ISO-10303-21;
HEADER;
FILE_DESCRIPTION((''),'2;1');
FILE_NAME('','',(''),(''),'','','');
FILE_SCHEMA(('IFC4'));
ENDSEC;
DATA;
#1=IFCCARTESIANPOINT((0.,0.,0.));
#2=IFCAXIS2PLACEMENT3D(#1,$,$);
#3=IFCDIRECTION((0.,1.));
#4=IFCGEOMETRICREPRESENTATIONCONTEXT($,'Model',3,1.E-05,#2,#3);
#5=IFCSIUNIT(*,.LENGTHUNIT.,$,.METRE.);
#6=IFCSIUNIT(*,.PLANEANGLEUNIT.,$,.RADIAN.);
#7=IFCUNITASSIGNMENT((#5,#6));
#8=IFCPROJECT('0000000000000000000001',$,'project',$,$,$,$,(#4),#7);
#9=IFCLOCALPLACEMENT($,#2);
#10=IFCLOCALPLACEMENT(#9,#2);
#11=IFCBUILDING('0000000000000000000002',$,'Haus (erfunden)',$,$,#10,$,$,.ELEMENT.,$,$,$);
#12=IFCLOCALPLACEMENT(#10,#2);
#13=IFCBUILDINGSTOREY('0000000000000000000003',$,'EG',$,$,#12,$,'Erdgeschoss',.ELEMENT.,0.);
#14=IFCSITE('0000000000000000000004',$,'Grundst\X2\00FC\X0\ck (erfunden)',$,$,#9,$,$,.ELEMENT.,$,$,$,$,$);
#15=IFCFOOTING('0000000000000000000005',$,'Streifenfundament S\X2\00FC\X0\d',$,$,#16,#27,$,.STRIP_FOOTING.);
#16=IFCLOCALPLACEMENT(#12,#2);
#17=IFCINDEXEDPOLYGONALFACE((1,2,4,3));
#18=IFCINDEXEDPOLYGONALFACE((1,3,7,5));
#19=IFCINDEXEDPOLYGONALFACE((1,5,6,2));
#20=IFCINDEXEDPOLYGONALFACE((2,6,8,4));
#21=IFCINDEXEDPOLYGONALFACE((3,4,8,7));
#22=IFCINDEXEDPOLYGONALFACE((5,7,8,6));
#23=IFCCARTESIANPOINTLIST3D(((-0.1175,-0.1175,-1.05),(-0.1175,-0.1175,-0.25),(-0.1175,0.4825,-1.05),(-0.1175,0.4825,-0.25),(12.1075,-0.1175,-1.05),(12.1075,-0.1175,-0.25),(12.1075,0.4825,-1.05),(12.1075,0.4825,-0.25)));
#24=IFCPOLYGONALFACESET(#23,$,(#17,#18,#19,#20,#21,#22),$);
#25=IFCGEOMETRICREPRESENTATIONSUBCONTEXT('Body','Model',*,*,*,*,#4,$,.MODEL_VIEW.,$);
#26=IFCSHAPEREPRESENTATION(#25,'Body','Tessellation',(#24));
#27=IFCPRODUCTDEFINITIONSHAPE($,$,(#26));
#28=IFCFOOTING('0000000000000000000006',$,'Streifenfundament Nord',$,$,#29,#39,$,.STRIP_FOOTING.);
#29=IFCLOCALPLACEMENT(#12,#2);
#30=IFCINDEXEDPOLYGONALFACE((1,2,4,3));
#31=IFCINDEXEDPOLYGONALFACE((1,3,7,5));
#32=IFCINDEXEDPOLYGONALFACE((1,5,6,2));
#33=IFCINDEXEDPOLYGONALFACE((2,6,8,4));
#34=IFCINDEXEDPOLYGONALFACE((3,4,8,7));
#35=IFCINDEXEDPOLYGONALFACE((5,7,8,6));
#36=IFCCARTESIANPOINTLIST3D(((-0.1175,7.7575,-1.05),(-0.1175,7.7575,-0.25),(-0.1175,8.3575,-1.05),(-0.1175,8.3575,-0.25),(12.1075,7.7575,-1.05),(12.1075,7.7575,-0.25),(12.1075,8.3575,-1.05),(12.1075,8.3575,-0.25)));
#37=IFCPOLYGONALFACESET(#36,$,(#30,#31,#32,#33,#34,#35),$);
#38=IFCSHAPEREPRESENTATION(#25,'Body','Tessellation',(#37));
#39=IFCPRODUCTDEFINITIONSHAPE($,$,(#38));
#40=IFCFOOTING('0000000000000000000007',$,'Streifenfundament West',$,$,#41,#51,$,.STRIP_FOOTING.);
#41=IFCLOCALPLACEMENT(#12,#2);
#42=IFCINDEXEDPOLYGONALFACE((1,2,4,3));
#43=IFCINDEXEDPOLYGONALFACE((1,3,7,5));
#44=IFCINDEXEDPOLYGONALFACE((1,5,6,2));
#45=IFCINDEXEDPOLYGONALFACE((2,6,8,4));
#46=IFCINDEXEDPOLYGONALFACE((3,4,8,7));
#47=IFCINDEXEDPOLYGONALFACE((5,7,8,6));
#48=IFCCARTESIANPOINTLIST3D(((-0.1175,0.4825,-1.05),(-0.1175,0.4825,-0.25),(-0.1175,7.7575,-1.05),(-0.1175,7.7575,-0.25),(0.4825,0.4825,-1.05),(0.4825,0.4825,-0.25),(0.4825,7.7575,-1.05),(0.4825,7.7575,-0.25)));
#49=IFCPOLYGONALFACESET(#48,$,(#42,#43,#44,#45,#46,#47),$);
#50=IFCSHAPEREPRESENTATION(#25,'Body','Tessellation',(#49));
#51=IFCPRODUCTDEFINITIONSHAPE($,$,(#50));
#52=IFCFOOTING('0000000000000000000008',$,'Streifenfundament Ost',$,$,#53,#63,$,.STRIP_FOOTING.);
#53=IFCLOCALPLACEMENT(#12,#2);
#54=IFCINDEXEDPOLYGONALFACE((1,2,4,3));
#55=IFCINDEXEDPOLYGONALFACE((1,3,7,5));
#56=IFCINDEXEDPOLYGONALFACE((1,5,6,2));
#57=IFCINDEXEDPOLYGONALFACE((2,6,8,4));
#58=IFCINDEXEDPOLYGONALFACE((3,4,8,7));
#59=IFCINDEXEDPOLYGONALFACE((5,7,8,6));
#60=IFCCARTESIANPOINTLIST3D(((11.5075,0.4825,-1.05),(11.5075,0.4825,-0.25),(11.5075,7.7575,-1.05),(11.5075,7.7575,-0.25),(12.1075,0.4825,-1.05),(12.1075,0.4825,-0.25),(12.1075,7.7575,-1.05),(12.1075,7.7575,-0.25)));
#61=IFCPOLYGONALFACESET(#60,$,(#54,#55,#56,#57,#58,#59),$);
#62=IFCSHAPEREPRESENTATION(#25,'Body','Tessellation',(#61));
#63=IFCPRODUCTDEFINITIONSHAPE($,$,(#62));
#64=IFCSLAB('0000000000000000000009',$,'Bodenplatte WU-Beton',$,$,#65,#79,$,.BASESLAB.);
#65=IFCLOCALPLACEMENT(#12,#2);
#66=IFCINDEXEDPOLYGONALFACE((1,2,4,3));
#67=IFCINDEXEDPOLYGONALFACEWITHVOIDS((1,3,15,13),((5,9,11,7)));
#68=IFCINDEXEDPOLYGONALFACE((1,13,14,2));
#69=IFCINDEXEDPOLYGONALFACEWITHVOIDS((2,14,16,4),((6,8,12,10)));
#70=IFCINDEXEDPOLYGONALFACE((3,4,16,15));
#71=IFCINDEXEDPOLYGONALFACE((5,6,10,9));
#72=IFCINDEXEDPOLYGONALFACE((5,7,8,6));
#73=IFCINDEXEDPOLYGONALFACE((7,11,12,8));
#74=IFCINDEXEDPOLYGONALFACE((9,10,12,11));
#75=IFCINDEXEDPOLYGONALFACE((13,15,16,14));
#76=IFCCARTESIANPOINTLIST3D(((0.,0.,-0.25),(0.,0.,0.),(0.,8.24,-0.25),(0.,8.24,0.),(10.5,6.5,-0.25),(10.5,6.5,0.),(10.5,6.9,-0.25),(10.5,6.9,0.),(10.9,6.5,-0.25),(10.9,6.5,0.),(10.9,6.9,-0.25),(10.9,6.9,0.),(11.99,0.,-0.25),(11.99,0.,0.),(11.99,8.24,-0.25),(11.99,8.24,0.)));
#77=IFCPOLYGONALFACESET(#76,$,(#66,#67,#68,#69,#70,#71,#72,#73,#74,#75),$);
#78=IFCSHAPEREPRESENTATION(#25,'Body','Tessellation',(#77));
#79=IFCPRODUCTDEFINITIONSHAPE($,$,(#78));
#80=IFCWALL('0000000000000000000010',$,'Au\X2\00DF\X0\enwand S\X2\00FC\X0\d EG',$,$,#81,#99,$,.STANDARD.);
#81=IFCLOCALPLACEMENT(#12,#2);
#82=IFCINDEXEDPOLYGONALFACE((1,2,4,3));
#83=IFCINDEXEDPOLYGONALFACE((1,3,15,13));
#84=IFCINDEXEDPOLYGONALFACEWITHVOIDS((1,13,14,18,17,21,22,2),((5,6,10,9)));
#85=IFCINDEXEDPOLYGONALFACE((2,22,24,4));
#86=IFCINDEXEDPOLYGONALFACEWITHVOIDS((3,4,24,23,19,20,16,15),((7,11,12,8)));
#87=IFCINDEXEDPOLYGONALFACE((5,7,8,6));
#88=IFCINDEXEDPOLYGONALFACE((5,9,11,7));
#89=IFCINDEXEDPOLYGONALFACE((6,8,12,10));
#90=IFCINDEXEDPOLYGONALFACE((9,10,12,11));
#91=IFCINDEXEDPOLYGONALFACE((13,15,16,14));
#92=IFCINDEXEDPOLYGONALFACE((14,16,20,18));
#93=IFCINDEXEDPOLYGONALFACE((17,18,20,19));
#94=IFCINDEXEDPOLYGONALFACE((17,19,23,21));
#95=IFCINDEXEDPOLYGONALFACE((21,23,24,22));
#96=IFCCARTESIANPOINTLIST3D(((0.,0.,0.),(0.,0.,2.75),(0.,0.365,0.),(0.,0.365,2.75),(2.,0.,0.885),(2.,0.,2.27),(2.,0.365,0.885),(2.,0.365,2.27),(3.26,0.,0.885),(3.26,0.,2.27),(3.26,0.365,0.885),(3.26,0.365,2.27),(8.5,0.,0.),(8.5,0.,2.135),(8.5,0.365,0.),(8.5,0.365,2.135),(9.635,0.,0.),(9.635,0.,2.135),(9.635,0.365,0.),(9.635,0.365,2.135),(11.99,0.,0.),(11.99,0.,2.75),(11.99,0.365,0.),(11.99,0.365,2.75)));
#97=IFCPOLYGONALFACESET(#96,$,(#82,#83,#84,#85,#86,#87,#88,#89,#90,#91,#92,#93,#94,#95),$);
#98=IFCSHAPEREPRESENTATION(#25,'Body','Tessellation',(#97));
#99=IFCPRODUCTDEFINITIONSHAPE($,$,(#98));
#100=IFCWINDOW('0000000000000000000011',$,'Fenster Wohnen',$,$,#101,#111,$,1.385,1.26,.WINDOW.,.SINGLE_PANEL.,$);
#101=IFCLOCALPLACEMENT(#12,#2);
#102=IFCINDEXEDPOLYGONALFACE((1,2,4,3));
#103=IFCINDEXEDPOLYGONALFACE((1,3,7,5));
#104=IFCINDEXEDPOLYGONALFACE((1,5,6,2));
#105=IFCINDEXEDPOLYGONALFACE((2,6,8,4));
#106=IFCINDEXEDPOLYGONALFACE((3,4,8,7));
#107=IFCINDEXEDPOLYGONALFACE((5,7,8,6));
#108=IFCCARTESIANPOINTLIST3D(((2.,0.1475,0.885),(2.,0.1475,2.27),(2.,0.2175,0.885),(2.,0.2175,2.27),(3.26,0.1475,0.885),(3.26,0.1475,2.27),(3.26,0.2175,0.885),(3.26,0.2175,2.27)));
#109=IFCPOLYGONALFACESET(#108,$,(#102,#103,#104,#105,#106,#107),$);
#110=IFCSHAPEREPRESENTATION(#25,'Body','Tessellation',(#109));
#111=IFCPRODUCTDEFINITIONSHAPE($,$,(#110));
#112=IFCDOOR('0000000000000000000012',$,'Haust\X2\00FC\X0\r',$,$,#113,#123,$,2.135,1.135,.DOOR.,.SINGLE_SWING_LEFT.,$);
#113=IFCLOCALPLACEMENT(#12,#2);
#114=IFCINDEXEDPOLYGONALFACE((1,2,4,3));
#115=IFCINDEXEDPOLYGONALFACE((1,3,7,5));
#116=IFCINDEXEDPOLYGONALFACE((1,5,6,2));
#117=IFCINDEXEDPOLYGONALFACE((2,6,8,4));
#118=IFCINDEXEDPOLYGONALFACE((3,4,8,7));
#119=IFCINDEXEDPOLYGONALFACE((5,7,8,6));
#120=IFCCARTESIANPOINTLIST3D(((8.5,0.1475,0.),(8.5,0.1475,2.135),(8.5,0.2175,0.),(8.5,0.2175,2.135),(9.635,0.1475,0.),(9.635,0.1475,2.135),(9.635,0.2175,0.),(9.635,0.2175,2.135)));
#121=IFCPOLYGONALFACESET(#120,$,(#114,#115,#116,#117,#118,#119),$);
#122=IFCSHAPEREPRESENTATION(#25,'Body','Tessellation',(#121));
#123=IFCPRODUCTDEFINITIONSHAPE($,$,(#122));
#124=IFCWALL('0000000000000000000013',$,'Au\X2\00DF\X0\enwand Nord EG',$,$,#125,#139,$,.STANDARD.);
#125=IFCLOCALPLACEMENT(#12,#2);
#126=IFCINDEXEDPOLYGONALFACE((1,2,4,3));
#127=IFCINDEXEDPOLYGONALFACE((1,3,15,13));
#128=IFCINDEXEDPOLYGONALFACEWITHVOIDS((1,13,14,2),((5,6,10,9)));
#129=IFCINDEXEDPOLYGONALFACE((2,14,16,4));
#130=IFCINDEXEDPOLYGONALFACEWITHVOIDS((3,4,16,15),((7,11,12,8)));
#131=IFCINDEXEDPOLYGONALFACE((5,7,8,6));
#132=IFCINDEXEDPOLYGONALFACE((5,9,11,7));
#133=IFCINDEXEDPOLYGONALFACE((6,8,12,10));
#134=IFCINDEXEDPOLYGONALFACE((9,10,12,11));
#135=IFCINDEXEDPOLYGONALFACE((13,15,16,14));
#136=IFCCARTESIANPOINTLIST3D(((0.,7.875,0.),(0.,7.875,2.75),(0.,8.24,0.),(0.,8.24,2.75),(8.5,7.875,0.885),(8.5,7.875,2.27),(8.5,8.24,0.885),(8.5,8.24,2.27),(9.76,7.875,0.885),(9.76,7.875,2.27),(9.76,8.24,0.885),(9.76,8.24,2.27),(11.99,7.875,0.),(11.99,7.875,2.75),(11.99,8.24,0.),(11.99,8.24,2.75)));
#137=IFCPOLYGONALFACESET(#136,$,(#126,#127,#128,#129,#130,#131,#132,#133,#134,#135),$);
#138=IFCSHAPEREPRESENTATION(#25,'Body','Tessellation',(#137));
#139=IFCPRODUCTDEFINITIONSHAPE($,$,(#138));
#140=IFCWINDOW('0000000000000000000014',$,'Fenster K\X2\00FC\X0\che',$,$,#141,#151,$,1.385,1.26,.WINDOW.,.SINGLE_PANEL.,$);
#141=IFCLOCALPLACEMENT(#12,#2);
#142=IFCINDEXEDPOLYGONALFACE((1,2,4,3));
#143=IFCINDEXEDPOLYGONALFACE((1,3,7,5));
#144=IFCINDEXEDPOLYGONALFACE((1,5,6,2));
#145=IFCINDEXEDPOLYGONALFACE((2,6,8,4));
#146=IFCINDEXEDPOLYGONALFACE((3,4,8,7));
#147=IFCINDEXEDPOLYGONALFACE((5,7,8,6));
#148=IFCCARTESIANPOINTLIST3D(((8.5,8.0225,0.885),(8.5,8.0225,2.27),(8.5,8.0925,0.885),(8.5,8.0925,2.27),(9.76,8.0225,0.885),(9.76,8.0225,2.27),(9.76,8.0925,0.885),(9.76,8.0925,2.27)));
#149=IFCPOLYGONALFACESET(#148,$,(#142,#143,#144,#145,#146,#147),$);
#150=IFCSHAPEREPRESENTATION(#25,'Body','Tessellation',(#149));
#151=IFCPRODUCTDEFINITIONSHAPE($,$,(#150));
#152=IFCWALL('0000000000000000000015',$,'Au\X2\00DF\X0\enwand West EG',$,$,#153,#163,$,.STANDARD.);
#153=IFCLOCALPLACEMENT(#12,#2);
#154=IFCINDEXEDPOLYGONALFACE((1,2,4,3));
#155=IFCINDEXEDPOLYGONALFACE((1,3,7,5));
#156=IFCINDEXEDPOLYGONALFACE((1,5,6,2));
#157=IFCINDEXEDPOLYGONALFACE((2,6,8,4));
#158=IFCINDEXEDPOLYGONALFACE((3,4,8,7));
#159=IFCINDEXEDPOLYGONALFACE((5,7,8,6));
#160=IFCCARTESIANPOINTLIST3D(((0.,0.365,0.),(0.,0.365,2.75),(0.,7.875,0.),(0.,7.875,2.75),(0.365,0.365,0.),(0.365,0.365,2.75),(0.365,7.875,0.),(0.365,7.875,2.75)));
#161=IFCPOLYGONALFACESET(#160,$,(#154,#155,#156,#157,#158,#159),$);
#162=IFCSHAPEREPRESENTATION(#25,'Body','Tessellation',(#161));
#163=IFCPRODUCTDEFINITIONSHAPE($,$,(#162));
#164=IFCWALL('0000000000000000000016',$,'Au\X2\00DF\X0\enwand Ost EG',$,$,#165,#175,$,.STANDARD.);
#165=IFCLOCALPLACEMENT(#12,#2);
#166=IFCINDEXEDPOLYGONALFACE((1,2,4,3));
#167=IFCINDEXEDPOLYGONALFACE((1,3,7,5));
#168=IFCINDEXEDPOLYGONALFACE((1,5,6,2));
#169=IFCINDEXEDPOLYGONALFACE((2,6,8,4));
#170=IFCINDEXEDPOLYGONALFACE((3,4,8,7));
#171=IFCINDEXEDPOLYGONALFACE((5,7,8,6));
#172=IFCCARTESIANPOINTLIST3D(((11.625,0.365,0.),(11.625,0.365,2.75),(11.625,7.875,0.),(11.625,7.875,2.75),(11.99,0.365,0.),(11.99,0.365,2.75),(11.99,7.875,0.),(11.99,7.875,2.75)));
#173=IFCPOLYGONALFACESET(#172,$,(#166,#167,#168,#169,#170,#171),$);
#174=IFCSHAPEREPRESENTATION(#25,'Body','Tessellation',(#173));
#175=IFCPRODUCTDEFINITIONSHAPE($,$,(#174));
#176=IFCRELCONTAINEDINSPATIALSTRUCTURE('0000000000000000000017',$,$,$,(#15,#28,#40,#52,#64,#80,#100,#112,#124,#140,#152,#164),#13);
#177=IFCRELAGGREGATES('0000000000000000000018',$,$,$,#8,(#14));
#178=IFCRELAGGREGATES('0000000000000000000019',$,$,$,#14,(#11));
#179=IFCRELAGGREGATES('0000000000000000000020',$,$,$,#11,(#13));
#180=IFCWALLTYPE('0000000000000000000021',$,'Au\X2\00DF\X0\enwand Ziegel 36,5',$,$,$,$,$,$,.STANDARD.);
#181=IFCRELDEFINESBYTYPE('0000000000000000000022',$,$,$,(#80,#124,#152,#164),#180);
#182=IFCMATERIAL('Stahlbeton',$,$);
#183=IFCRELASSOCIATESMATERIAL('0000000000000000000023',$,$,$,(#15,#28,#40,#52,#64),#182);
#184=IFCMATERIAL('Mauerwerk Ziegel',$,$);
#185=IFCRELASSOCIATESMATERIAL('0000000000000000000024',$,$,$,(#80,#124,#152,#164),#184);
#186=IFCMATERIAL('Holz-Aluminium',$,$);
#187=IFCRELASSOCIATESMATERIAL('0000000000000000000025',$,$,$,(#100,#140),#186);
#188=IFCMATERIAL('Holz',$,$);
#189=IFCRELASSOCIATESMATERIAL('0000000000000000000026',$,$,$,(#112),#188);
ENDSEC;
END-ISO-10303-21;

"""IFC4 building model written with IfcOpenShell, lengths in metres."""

from ifc_helpers import new_model, si_unit, direction, frame, frame_2d, origin, place, context, subcontext, project, spatial, rectangle, extrude, material, type_object, element, fill, save


model = new_model("IFC4")

# Units and contexts
model_context = context("Model", 3, precision=1e-05, world=origin(), true_north=direction((0.0, 1.0)))
body_context = subcontext(model_context, "Body", "Model", "MODEL_VIEW")
ifc_project = project(units=[si_unit("LENGTHUNIT", "METRE"), si_unit("PLANEANGLEUNIT", "RADIAN")], contexts=[model_context])

# Site, building, storey
site_placement = place(None, origin())
site = spatial("IfcSite", under=ifc_project, at=site_placement, Name="Grundstück (erfunden)", CompositionType="ELEMENT")
building_placement = place(site_placement, origin())
building = spatial("IfcBuilding", under=site, at=building_placement, Name="Haus (erfunden)", CompositionType="ELEMENT")
storey_placement = place(building_placement, origin())
storey = spatial("IfcBuildingStorey", under=building, at=storey_placement, Name="EG", LongName="Erdgeschoss", CompositionType="ELEMENT", Elevation=0.0)

# Footings
ifc_material_1 = material(Name="Stahlbeton")
for number, where, name in (
    (1, (-0.1175, -0.1175, -1.05), "Streifenfundament Süd"),
    (2, (-0.1175, 7.7575, -1.05), "Streifenfundament Nord"),
):
    element("IfcFooting", number, at=place(storey_placement, frame(where)), inside=storey, material=ifc_material_1, Name=name, PredefinedType="STRIP_FOOTING", context=body_context, shape_type="SweptSolid", body=[
        extrude(rectangle(XDim=12.225, YDim=0.6, at=frame_2d((6.1125, 0.3))), origin(), (0.0, 0.0, 1.0), 0.8),
    ])
for number, where, name in (
    (3, (-0.1175, 0.4825, -1.05), "Streifenfundament West"),
    (4, (11.5075, 0.4825, -1.05), "Streifenfundament Ost"),
):
    element("IfcFooting", number, at=place(storey_placement, frame(where)), inside=storey, material=ifc_material_1, Name=name, PredefinedType="STRIP_FOOTING", context=body_context, shape_type="SweptSolid", body=[
        extrude(rectangle(XDim=0.6, YDim=7.275, at=frame_2d((0.3, 3.6375))), origin(), (0.0, 0.0, 1.0), 0.8),
    ])

# Slab, opening
slab_placement = place(storey_placement, frame((0.0, 0.0, -0.25)))
slab = element("IfcSlab", 5, at=slab_placement, inside=storey, material=ifc_material_1, Name="Bodenplatte WU-Beton", PredefinedType="BASESLAB", context=body_context, shape_type="SweptSolid", body=[
    extrude(rectangle(XDim=11.99, YDim=8.24, at=frame_2d((5.995, 4.12))), origin(), (0.0, 0.0, 1.0), 0.25),
])
opening_1_placement = place(slab_placement, frame((10.5, 6.5, -0.05)))
element("IfcOpeningElement", 6, at=opening_1_placement, cuts=slab, PredefinedType="OPENING", context=body_context, shape_type="SweptSolid", body=[
    extrude(rectangle(XDim=0.4, YDim=0.4, at=frame_2d((0.2, 0.2))), origin(), (0.0, 0.0, 1.0), 0.35),
])

# Wall, openings, window, door
ifc_material_2 = material(Name="Mauerwerk Ziegel")
wall_type_1 = type_object("IfcWallType", Name="Außenwand Ziegel 36,5", PredefinedType="STANDARD")
wall_1_placement = place(storey_placement, origin())
wall_1 = element("IfcWall", 7, at=wall_1_placement, inside=storey, type_object=wall_type_1, material=ifc_material_2, Name="Außenwand Süd EG", PredefinedType="STANDARD", context=body_context, shape_type="SweptSolid", body=[
    extrude(rectangle(XDim=11.99, YDim=0.365, at=frame_2d((5.995, 0.1825))), origin(), (0.0, 0.0, 1.0), 2.75),
])
opening_2_placement = place(wall_1_placement, frame((2.0, -0.05, 0.885)))
opening_2 = element("IfcOpeningElement", 8, at=opening_2_placement, cuts=wall_1, PredefinedType="OPENING", context=body_context, shape_type="SweptSolid", body=[
    extrude(rectangle(XDim=1.26, YDim=0.465, at=frame_2d((0.63, 0.2325))), origin(), (0.0, 0.0, 1.0), 1.385),
])
opening_3_placement = place(wall_1_placement, frame((8.5, -0.05, 0.0)))
opening_3 = element("IfcOpeningElement", 9, at=opening_3_placement, cuts=wall_1, PredefinedType="OPENING", context=body_context, shape_type="SweptSolid", body=[
    extrude(rectangle(XDim=1.135, YDim=0.465, at=frame_2d((0.5675, 0.2325))), origin(), (0.0, 0.0, 1.0), 2.135),
])
ifc_material_3 = material(Name="Holz-Aluminium")
window_1_placement = place(opening_2_placement, frame((0.0, 0.1975, 0.0)))
window_1 = element("IfcWindow", 10, at=window_1_placement, inside=storey, material=ifc_material_3, Name="Fenster Wohnen", OverallHeight=1.385, OverallWidth=1.26, PartitioningType="SINGLE_PANEL", PredefinedType="WINDOW", context=body_context, shape_type="SweptSolid", body=[
    extrude(rectangle(XDim=1.26, YDim=0.07, at=frame_2d((0.63, 0.035))), origin(), (0.0, 0.0, 1.0), 1.385),
])
fill(opening_2, window_1)
ifc_material_4 = material(Name="Holz")
door_1_placement = place(opening_3_placement, frame((0.0, 0.1975, 0.0)))
door_1 = element("IfcDoor", 11, at=door_1_placement, inside=storey, material=ifc_material_4, Name="Haustür", OperationType="SINGLE_SWING_LEFT", OverallHeight=2.135, OverallWidth=1.135, PredefinedType="DOOR", context=body_context, shape_type="SweptSolid", body=[
    extrude(rectangle(XDim=1.135, YDim=0.07, at=frame_2d((0.5675, 0.035))), origin(), (0.0, 0.0, 1.0), 2.135),
])
fill(opening_3, door_1)

# Wall, opening, window
wall_2_placement = place(storey_placement, frame((0.0, 7.875, 0.0)))
wall_2 = element("IfcWall", 12, at=wall_2_placement, inside=storey, type_object=wall_type_1, material=ifc_material_2, Name="Außenwand Nord EG", PredefinedType="STANDARD", context=body_context, shape_type="SweptSolid", body=[
    extrude(rectangle(XDim=11.99, YDim=0.365, at=frame_2d((5.995, 0.1825))), origin(), (0.0, 0.0, 1.0), 2.75),
])
opening_4_placement = place(wall_2_placement, frame((8.5, -0.05, 0.885)))
opening_4 = element("IfcOpeningElement", 13, at=opening_4_placement, cuts=wall_2, PredefinedType="OPENING", context=body_context, shape_type="SweptSolid", body=[
    extrude(rectangle(XDim=1.26, YDim=0.465, at=frame_2d((0.63, 0.2325))), origin(), (0.0, 0.0, 1.0), 1.385),
])
window_2_placement = place(opening_4_placement, frame((0.0, 0.1975, 0.0)))
window_2 = element("IfcWindow", 14, at=window_2_placement, inside=storey, material=ifc_material_3, Name="Fenster Küche", OverallHeight=1.385, OverallWidth=1.26, PartitioningType="SINGLE_PANEL", PredefinedType="WINDOW", context=body_context, shape_type="SweptSolid", body=[
    extrude(rectangle(XDim=1.26, YDim=0.07, at=frame_2d((0.63, 0.035))), origin(), (0.0, 0.0, 1.0), 1.385),
])
fill(opening_4, window_2)

# Walls
for number, where, name in (
    (15, (0.0, 0.365, 0.0), "Außenwand West EG"),
    (16, (11.625, 0.365, 0.0), "Außenwand Ost EG"),
):
    element("IfcWall", number, at=place(storey_placement, frame(where)), inside=storey, type_object=wall_type_1, material=ifc_material_2, Name=name, PredefinedType="STANDARD", context=body_context, shape_type="SweptSolid", body=[
        extrude(rectangle(XDim=0.365, YDim=7.51, at=frame_2d((0.1825, 3.755))), origin(), (0.0, 0.0, 1.0), 2.75),
    ])

save(model, "model.ifc")
